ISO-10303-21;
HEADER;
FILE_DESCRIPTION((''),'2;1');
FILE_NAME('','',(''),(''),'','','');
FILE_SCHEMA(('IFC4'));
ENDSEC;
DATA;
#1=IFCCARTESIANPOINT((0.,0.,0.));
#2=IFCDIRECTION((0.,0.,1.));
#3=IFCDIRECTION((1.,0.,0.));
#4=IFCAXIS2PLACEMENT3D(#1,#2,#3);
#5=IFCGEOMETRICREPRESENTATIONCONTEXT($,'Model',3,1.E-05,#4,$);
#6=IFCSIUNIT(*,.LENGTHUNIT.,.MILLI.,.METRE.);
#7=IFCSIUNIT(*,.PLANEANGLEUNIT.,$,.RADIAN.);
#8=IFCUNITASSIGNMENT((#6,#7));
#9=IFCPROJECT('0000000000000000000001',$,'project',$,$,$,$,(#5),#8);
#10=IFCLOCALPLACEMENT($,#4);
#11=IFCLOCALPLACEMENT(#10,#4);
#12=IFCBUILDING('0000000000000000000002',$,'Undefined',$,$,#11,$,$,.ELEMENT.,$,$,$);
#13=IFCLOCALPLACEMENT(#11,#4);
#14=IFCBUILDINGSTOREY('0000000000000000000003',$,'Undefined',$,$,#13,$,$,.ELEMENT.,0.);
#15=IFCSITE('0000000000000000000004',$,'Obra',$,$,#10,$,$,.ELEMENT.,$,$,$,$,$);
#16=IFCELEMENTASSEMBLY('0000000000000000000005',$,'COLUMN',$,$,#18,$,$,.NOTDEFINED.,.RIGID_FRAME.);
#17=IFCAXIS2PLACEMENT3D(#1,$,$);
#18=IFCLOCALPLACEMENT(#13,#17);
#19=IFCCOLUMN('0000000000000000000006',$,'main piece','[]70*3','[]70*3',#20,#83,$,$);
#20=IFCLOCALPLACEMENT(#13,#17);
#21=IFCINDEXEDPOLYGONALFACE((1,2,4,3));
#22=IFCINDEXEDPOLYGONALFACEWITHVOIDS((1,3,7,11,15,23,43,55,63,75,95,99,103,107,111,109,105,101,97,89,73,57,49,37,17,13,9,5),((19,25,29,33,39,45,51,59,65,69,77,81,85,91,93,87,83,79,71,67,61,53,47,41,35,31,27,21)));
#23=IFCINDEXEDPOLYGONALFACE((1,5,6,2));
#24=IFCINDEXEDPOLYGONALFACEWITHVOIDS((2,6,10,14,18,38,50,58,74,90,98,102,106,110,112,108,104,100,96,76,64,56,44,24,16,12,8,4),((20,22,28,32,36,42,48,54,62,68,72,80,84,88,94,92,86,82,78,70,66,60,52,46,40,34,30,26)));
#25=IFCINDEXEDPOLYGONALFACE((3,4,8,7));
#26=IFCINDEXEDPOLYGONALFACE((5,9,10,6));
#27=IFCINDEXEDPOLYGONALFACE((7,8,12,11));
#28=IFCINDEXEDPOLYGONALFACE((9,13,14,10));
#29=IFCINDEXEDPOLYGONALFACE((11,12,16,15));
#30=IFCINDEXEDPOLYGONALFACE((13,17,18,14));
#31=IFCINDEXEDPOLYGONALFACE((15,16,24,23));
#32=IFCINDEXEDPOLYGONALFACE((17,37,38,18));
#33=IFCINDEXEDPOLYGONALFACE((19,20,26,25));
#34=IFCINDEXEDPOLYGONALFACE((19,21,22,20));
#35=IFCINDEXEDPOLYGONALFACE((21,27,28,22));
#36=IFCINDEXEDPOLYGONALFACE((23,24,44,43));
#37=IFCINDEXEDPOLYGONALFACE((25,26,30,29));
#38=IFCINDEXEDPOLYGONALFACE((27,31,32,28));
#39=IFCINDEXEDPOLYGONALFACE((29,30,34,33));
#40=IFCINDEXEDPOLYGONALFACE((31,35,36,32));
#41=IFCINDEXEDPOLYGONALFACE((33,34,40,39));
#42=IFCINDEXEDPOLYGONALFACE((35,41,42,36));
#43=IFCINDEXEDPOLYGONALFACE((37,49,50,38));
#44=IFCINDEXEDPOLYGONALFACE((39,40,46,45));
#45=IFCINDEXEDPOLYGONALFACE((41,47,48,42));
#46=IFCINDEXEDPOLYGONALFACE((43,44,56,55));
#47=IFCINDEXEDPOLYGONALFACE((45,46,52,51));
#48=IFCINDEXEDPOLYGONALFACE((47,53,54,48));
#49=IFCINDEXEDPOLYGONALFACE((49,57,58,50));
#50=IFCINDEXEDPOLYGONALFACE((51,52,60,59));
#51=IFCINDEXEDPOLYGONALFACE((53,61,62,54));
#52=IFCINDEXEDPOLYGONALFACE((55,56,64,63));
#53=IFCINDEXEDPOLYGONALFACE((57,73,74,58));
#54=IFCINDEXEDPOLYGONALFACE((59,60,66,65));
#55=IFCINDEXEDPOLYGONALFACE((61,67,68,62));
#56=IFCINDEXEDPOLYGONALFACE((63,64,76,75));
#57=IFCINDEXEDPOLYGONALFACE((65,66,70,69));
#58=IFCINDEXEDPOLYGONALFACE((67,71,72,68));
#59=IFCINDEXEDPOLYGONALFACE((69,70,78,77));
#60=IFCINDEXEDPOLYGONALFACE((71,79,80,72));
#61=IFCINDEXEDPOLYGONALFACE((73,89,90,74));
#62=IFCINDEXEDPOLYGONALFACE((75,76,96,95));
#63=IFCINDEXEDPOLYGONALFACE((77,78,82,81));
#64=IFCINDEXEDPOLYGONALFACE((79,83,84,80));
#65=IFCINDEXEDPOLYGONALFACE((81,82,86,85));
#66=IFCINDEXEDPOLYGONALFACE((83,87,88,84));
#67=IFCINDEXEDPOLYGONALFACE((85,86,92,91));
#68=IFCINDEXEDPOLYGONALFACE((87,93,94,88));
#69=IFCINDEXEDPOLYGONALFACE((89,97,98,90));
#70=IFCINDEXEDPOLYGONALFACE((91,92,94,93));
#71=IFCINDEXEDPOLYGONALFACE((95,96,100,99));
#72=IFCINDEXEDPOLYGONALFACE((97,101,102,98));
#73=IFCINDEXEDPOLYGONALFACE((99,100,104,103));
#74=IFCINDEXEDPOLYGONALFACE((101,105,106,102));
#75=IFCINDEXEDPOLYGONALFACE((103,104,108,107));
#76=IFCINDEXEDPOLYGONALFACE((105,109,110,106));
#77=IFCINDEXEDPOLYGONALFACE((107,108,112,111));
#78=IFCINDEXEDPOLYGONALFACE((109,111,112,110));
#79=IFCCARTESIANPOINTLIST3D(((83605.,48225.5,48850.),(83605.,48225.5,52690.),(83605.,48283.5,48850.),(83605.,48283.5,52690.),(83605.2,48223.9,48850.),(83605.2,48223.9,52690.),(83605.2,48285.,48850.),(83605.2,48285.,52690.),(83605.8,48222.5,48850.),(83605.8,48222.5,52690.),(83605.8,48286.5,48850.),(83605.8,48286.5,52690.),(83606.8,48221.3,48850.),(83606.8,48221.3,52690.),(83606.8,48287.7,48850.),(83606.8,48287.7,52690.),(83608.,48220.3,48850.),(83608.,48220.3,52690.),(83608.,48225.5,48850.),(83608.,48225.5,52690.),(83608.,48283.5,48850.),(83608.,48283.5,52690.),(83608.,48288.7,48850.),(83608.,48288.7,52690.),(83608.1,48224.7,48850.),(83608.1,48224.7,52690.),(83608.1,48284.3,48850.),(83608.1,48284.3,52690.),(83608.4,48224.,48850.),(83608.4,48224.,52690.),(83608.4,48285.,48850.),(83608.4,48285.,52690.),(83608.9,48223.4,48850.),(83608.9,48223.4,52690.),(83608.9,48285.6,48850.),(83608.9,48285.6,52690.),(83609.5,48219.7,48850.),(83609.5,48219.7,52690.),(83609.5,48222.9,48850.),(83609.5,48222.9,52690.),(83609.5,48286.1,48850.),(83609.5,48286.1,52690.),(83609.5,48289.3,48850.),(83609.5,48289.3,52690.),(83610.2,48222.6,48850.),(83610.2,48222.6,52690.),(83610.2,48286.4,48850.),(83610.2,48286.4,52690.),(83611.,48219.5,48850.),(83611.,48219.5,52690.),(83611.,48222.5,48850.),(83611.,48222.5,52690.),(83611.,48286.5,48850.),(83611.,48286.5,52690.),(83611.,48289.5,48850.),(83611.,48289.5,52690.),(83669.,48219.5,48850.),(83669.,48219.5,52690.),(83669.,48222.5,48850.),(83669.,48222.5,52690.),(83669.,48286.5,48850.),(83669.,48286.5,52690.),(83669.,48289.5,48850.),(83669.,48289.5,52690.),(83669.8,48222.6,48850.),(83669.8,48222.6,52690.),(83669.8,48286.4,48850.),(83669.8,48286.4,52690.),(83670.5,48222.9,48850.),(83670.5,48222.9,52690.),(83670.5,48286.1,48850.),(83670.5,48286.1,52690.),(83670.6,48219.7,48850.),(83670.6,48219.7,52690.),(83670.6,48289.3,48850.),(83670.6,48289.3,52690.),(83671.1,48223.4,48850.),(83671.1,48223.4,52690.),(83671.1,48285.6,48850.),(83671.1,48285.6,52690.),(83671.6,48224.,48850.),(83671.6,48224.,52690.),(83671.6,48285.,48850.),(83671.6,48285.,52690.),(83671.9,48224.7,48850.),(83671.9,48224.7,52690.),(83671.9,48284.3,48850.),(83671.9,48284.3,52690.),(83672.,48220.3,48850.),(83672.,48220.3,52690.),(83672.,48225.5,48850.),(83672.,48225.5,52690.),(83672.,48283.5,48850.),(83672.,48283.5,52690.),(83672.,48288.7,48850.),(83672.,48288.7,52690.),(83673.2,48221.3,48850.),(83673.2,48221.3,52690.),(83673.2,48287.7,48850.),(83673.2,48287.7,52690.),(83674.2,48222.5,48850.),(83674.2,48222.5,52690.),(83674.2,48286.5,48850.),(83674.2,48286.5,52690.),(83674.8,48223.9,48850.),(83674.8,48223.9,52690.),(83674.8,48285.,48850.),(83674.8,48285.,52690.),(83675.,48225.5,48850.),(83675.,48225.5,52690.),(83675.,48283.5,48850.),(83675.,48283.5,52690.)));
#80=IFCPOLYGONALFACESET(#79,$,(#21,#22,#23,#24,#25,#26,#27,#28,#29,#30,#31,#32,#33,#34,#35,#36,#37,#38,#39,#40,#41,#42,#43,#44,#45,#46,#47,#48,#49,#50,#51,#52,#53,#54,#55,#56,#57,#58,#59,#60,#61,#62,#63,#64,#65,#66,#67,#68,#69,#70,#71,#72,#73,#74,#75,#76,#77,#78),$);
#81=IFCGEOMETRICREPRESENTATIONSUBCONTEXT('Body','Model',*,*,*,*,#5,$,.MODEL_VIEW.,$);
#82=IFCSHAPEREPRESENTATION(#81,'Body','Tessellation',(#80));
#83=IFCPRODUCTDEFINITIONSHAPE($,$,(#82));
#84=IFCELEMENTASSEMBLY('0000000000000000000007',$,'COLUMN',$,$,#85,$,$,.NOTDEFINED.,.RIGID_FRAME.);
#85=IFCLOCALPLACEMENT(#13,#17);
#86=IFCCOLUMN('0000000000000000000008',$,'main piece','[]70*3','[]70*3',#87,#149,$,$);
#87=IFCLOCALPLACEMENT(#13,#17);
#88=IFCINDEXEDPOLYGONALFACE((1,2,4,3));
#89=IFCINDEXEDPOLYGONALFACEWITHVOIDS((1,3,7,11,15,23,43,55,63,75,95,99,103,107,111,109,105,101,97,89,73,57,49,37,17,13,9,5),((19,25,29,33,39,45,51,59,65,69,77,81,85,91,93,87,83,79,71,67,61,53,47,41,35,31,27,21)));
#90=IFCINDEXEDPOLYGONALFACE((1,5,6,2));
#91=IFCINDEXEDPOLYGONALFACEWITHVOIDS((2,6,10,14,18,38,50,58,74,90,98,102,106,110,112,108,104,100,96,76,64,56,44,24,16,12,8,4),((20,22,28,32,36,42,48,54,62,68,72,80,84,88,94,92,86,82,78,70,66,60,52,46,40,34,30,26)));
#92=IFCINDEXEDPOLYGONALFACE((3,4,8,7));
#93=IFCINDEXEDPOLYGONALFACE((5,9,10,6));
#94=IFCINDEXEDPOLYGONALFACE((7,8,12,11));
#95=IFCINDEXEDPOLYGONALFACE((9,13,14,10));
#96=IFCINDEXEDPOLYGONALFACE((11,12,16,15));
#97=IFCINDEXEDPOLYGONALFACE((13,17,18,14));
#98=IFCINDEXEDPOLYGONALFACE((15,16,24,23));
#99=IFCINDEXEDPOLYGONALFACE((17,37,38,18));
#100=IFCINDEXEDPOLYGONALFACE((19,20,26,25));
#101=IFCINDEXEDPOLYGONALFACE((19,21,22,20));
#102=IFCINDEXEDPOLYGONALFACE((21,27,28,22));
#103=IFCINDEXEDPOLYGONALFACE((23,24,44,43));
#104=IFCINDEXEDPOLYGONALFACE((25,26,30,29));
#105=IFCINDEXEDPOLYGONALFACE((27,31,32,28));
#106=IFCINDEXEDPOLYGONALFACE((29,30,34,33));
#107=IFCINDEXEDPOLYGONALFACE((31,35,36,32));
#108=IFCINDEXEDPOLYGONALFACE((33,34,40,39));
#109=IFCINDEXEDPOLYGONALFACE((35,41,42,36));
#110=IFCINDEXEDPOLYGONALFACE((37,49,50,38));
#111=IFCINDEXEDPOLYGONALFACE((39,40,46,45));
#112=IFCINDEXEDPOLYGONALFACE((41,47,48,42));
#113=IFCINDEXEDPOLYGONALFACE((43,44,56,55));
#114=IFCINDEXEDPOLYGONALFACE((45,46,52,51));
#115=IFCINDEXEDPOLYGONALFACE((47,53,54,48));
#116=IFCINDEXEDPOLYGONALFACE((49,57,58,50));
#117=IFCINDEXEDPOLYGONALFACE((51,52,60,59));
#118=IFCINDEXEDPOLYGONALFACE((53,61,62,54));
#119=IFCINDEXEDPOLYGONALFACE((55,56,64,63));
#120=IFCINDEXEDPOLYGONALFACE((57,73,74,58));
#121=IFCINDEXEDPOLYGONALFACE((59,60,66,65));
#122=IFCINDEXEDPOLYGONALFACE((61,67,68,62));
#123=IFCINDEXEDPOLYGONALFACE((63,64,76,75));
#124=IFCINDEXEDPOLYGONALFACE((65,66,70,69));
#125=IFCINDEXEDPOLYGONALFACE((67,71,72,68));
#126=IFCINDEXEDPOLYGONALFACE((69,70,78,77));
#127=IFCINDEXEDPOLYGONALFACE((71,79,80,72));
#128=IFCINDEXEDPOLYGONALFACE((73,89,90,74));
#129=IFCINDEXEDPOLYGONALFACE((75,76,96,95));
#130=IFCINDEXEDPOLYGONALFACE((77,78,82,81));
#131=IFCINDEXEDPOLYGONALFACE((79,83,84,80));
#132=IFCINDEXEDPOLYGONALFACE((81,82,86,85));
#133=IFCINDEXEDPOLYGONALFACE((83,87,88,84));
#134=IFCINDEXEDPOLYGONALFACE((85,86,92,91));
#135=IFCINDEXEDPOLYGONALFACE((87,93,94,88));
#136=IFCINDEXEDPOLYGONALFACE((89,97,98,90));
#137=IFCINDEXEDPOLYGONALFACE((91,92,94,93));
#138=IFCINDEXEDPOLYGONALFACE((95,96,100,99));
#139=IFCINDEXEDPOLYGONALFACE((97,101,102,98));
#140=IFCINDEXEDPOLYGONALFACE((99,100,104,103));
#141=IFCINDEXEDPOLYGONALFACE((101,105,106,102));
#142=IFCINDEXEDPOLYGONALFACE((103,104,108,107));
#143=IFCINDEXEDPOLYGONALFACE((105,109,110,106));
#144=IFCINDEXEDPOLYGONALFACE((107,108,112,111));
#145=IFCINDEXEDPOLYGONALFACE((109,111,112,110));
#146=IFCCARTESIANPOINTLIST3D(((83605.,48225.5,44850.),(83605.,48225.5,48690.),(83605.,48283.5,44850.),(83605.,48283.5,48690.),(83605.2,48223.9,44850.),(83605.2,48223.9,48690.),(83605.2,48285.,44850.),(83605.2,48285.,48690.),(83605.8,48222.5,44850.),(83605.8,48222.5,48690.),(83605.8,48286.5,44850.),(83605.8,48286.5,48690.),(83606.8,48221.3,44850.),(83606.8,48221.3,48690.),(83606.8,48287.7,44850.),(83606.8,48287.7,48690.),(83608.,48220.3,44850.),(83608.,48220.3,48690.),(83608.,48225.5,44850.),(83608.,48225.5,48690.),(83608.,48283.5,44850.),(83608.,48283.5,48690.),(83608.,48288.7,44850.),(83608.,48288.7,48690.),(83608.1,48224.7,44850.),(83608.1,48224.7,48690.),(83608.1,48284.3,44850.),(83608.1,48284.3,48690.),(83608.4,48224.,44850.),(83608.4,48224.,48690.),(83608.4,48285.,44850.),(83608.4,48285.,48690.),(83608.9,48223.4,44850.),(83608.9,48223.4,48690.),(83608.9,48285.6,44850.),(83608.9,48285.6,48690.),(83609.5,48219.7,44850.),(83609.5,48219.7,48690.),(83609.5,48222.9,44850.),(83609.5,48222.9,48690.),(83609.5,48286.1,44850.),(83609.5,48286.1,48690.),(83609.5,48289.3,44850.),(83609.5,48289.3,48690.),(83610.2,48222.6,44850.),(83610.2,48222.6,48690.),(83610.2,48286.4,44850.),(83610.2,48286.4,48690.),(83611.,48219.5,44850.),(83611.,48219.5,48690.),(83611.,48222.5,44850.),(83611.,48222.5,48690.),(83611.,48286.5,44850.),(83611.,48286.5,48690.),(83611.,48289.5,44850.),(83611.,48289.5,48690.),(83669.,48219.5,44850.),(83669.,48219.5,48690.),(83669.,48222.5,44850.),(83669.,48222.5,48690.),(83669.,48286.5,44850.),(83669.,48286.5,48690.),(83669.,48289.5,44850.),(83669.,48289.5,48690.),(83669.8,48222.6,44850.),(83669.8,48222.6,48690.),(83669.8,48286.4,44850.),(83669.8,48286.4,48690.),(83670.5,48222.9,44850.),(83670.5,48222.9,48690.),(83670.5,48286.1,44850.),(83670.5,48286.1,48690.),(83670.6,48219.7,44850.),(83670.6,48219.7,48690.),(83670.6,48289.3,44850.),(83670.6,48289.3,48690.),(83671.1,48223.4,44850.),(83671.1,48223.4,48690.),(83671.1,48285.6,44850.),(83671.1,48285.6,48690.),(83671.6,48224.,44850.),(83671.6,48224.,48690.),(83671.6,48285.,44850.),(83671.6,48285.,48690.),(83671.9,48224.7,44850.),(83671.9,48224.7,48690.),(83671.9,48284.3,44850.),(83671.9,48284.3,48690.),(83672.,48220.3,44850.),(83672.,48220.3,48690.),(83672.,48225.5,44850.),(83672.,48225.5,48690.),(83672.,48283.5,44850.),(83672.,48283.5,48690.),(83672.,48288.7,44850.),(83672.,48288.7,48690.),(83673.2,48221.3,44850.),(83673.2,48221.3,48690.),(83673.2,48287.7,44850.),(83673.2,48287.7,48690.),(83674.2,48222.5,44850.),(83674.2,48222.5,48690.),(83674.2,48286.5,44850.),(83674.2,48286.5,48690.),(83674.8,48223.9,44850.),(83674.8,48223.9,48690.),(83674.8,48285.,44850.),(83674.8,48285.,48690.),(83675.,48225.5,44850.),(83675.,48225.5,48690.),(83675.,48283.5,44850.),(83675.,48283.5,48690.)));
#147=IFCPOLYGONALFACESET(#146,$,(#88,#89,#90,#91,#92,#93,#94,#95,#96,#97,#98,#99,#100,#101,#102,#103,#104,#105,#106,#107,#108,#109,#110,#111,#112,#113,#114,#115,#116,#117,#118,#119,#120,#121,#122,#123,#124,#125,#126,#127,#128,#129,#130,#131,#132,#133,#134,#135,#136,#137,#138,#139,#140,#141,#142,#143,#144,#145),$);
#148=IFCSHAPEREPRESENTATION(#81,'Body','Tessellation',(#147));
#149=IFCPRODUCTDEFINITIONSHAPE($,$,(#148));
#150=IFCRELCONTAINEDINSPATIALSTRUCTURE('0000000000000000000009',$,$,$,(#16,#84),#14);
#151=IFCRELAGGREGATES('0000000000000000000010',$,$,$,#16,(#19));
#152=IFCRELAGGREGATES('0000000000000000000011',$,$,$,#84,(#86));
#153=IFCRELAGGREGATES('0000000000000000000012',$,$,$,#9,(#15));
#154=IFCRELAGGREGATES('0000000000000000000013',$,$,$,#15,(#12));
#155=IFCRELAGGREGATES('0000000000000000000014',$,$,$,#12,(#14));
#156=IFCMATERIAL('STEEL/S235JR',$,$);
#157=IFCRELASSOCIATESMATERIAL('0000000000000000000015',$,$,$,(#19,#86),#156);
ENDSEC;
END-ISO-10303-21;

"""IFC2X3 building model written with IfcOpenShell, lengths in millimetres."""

from ifc_helpers import new_model, si_unit, frame, origin_with_axes, origin_2d_with_axis, place, context, subcontext, project, spatial, hollow_rectangle, extrude, material, element, aggregate, save


model = new_model("IFC2X3")

# Units and contexts
model_context = context("Model", 3, precision=1e-05, world=origin_with_axes())
body_context = subcontext(model_context, "Body", "Model", "MODEL_VIEW")
ifc_project = project(units=[si_unit("LENGTHUNIT", "METRE", prefix="MILLI"), si_unit("PLANEANGLEUNIT", "RADIAN")], contexts=[model_context])

# Site, building, storey
site_placement = place(None, origin_with_axes())
site = spatial("IfcSite", under=ifc_project, at=site_placement, Name="Obra", CompositionType="ELEMENT")
building_placement = place(site_placement, origin_with_axes())
building = spatial("IfcBuilding", under=site, at=building_placement, Name="Undefined", CompositionType="ELEMENT")
storey_placement = place(building_placement, origin_with_axes())
storey = spatial("IfcBuildingStorey", under=building, at=storey_placement, Name="Undefined", CompositionType="ELEMENT", Elevation=0.0)

# Element assemblies, columns
ifc_material = material(Name="STEEL/S235JR")
assembly_1_placement = place(storey_placement, origin_with_axes())
assembly_1 = element("IfcElementAssembly", 1, at=assembly_1_placement, inside=storey, Name="COLUMN", AssemblyPlace="NOTDEFINED", PredefinedType="RIGID_FRAME")
column_1_placement = place(assembly_1_placement, frame((83640.0, 48254.5, 48850.0), z_axis=(0.0, 0.0, 1.0), x_axis=(0.0, 1.0, 0.0)))
column_1 = element("IfcColumn", 2, at=column_1_placement, material=ifc_material, Name="main piece", Description="[]70*3", ObjectType="[]70*3", context=body_context, shape_type="SweptSolid", body=[
    extrude(hollow_rectangle(XDim=70.0, YDim=70.0, WallThickness=3.0, InnerFilletRadius=3.0, OuterFilletRadius=6.0, at=origin_2d_with_axis()), frame((0.0, 0.0, 3840.0), z_axis=(0.0, 0.0, -1.0), x_axis=(0.0, 1.0, 0.0)), (0.0, 0.0, 1.0), 3840.0),
])
aggregate(assembly_1, [column_1])
assembly_2_placement = place(storey_placement, origin_with_axes())
assembly_2 = element("IfcElementAssembly", 3, at=assembly_2_placement, inside=storey, Name="COLUMN", AssemblyPlace="NOTDEFINED", PredefinedType="RIGID_FRAME")
column_2_placement = place(assembly_2_placement, frame((83640.0, 48254.5, 44850.0), z_axis=(0.0, 0.0, 1.0), x_axis=(0.0, 1.0, 0.0)))
column_2 = element("IfcColumn", 4, at=column_2_placement, material=ifc_material, Name="main piece", Description="[]70*3", ObjectType="[]70*3", context=body_context, shape_type="SweptSolid", body=[
    extrude(hollow_rectangle(XDim=70.0, YDim=70.0, WallThickness=3.0, InnerFilletRadius=3.0, OuterFilletRadius=6.0, at=origin_2d_with_axis()), frame((0.0, 0.0, 3840.0), z_axis=(0.0, 0.0, -1.0), x_axis=(0.0, 1.0, 0.0)), (0.0, 0.0, 1.0), 3840.0),
])
aggregate(assembly_2, [column_2])

save(model, "model.ifc")
